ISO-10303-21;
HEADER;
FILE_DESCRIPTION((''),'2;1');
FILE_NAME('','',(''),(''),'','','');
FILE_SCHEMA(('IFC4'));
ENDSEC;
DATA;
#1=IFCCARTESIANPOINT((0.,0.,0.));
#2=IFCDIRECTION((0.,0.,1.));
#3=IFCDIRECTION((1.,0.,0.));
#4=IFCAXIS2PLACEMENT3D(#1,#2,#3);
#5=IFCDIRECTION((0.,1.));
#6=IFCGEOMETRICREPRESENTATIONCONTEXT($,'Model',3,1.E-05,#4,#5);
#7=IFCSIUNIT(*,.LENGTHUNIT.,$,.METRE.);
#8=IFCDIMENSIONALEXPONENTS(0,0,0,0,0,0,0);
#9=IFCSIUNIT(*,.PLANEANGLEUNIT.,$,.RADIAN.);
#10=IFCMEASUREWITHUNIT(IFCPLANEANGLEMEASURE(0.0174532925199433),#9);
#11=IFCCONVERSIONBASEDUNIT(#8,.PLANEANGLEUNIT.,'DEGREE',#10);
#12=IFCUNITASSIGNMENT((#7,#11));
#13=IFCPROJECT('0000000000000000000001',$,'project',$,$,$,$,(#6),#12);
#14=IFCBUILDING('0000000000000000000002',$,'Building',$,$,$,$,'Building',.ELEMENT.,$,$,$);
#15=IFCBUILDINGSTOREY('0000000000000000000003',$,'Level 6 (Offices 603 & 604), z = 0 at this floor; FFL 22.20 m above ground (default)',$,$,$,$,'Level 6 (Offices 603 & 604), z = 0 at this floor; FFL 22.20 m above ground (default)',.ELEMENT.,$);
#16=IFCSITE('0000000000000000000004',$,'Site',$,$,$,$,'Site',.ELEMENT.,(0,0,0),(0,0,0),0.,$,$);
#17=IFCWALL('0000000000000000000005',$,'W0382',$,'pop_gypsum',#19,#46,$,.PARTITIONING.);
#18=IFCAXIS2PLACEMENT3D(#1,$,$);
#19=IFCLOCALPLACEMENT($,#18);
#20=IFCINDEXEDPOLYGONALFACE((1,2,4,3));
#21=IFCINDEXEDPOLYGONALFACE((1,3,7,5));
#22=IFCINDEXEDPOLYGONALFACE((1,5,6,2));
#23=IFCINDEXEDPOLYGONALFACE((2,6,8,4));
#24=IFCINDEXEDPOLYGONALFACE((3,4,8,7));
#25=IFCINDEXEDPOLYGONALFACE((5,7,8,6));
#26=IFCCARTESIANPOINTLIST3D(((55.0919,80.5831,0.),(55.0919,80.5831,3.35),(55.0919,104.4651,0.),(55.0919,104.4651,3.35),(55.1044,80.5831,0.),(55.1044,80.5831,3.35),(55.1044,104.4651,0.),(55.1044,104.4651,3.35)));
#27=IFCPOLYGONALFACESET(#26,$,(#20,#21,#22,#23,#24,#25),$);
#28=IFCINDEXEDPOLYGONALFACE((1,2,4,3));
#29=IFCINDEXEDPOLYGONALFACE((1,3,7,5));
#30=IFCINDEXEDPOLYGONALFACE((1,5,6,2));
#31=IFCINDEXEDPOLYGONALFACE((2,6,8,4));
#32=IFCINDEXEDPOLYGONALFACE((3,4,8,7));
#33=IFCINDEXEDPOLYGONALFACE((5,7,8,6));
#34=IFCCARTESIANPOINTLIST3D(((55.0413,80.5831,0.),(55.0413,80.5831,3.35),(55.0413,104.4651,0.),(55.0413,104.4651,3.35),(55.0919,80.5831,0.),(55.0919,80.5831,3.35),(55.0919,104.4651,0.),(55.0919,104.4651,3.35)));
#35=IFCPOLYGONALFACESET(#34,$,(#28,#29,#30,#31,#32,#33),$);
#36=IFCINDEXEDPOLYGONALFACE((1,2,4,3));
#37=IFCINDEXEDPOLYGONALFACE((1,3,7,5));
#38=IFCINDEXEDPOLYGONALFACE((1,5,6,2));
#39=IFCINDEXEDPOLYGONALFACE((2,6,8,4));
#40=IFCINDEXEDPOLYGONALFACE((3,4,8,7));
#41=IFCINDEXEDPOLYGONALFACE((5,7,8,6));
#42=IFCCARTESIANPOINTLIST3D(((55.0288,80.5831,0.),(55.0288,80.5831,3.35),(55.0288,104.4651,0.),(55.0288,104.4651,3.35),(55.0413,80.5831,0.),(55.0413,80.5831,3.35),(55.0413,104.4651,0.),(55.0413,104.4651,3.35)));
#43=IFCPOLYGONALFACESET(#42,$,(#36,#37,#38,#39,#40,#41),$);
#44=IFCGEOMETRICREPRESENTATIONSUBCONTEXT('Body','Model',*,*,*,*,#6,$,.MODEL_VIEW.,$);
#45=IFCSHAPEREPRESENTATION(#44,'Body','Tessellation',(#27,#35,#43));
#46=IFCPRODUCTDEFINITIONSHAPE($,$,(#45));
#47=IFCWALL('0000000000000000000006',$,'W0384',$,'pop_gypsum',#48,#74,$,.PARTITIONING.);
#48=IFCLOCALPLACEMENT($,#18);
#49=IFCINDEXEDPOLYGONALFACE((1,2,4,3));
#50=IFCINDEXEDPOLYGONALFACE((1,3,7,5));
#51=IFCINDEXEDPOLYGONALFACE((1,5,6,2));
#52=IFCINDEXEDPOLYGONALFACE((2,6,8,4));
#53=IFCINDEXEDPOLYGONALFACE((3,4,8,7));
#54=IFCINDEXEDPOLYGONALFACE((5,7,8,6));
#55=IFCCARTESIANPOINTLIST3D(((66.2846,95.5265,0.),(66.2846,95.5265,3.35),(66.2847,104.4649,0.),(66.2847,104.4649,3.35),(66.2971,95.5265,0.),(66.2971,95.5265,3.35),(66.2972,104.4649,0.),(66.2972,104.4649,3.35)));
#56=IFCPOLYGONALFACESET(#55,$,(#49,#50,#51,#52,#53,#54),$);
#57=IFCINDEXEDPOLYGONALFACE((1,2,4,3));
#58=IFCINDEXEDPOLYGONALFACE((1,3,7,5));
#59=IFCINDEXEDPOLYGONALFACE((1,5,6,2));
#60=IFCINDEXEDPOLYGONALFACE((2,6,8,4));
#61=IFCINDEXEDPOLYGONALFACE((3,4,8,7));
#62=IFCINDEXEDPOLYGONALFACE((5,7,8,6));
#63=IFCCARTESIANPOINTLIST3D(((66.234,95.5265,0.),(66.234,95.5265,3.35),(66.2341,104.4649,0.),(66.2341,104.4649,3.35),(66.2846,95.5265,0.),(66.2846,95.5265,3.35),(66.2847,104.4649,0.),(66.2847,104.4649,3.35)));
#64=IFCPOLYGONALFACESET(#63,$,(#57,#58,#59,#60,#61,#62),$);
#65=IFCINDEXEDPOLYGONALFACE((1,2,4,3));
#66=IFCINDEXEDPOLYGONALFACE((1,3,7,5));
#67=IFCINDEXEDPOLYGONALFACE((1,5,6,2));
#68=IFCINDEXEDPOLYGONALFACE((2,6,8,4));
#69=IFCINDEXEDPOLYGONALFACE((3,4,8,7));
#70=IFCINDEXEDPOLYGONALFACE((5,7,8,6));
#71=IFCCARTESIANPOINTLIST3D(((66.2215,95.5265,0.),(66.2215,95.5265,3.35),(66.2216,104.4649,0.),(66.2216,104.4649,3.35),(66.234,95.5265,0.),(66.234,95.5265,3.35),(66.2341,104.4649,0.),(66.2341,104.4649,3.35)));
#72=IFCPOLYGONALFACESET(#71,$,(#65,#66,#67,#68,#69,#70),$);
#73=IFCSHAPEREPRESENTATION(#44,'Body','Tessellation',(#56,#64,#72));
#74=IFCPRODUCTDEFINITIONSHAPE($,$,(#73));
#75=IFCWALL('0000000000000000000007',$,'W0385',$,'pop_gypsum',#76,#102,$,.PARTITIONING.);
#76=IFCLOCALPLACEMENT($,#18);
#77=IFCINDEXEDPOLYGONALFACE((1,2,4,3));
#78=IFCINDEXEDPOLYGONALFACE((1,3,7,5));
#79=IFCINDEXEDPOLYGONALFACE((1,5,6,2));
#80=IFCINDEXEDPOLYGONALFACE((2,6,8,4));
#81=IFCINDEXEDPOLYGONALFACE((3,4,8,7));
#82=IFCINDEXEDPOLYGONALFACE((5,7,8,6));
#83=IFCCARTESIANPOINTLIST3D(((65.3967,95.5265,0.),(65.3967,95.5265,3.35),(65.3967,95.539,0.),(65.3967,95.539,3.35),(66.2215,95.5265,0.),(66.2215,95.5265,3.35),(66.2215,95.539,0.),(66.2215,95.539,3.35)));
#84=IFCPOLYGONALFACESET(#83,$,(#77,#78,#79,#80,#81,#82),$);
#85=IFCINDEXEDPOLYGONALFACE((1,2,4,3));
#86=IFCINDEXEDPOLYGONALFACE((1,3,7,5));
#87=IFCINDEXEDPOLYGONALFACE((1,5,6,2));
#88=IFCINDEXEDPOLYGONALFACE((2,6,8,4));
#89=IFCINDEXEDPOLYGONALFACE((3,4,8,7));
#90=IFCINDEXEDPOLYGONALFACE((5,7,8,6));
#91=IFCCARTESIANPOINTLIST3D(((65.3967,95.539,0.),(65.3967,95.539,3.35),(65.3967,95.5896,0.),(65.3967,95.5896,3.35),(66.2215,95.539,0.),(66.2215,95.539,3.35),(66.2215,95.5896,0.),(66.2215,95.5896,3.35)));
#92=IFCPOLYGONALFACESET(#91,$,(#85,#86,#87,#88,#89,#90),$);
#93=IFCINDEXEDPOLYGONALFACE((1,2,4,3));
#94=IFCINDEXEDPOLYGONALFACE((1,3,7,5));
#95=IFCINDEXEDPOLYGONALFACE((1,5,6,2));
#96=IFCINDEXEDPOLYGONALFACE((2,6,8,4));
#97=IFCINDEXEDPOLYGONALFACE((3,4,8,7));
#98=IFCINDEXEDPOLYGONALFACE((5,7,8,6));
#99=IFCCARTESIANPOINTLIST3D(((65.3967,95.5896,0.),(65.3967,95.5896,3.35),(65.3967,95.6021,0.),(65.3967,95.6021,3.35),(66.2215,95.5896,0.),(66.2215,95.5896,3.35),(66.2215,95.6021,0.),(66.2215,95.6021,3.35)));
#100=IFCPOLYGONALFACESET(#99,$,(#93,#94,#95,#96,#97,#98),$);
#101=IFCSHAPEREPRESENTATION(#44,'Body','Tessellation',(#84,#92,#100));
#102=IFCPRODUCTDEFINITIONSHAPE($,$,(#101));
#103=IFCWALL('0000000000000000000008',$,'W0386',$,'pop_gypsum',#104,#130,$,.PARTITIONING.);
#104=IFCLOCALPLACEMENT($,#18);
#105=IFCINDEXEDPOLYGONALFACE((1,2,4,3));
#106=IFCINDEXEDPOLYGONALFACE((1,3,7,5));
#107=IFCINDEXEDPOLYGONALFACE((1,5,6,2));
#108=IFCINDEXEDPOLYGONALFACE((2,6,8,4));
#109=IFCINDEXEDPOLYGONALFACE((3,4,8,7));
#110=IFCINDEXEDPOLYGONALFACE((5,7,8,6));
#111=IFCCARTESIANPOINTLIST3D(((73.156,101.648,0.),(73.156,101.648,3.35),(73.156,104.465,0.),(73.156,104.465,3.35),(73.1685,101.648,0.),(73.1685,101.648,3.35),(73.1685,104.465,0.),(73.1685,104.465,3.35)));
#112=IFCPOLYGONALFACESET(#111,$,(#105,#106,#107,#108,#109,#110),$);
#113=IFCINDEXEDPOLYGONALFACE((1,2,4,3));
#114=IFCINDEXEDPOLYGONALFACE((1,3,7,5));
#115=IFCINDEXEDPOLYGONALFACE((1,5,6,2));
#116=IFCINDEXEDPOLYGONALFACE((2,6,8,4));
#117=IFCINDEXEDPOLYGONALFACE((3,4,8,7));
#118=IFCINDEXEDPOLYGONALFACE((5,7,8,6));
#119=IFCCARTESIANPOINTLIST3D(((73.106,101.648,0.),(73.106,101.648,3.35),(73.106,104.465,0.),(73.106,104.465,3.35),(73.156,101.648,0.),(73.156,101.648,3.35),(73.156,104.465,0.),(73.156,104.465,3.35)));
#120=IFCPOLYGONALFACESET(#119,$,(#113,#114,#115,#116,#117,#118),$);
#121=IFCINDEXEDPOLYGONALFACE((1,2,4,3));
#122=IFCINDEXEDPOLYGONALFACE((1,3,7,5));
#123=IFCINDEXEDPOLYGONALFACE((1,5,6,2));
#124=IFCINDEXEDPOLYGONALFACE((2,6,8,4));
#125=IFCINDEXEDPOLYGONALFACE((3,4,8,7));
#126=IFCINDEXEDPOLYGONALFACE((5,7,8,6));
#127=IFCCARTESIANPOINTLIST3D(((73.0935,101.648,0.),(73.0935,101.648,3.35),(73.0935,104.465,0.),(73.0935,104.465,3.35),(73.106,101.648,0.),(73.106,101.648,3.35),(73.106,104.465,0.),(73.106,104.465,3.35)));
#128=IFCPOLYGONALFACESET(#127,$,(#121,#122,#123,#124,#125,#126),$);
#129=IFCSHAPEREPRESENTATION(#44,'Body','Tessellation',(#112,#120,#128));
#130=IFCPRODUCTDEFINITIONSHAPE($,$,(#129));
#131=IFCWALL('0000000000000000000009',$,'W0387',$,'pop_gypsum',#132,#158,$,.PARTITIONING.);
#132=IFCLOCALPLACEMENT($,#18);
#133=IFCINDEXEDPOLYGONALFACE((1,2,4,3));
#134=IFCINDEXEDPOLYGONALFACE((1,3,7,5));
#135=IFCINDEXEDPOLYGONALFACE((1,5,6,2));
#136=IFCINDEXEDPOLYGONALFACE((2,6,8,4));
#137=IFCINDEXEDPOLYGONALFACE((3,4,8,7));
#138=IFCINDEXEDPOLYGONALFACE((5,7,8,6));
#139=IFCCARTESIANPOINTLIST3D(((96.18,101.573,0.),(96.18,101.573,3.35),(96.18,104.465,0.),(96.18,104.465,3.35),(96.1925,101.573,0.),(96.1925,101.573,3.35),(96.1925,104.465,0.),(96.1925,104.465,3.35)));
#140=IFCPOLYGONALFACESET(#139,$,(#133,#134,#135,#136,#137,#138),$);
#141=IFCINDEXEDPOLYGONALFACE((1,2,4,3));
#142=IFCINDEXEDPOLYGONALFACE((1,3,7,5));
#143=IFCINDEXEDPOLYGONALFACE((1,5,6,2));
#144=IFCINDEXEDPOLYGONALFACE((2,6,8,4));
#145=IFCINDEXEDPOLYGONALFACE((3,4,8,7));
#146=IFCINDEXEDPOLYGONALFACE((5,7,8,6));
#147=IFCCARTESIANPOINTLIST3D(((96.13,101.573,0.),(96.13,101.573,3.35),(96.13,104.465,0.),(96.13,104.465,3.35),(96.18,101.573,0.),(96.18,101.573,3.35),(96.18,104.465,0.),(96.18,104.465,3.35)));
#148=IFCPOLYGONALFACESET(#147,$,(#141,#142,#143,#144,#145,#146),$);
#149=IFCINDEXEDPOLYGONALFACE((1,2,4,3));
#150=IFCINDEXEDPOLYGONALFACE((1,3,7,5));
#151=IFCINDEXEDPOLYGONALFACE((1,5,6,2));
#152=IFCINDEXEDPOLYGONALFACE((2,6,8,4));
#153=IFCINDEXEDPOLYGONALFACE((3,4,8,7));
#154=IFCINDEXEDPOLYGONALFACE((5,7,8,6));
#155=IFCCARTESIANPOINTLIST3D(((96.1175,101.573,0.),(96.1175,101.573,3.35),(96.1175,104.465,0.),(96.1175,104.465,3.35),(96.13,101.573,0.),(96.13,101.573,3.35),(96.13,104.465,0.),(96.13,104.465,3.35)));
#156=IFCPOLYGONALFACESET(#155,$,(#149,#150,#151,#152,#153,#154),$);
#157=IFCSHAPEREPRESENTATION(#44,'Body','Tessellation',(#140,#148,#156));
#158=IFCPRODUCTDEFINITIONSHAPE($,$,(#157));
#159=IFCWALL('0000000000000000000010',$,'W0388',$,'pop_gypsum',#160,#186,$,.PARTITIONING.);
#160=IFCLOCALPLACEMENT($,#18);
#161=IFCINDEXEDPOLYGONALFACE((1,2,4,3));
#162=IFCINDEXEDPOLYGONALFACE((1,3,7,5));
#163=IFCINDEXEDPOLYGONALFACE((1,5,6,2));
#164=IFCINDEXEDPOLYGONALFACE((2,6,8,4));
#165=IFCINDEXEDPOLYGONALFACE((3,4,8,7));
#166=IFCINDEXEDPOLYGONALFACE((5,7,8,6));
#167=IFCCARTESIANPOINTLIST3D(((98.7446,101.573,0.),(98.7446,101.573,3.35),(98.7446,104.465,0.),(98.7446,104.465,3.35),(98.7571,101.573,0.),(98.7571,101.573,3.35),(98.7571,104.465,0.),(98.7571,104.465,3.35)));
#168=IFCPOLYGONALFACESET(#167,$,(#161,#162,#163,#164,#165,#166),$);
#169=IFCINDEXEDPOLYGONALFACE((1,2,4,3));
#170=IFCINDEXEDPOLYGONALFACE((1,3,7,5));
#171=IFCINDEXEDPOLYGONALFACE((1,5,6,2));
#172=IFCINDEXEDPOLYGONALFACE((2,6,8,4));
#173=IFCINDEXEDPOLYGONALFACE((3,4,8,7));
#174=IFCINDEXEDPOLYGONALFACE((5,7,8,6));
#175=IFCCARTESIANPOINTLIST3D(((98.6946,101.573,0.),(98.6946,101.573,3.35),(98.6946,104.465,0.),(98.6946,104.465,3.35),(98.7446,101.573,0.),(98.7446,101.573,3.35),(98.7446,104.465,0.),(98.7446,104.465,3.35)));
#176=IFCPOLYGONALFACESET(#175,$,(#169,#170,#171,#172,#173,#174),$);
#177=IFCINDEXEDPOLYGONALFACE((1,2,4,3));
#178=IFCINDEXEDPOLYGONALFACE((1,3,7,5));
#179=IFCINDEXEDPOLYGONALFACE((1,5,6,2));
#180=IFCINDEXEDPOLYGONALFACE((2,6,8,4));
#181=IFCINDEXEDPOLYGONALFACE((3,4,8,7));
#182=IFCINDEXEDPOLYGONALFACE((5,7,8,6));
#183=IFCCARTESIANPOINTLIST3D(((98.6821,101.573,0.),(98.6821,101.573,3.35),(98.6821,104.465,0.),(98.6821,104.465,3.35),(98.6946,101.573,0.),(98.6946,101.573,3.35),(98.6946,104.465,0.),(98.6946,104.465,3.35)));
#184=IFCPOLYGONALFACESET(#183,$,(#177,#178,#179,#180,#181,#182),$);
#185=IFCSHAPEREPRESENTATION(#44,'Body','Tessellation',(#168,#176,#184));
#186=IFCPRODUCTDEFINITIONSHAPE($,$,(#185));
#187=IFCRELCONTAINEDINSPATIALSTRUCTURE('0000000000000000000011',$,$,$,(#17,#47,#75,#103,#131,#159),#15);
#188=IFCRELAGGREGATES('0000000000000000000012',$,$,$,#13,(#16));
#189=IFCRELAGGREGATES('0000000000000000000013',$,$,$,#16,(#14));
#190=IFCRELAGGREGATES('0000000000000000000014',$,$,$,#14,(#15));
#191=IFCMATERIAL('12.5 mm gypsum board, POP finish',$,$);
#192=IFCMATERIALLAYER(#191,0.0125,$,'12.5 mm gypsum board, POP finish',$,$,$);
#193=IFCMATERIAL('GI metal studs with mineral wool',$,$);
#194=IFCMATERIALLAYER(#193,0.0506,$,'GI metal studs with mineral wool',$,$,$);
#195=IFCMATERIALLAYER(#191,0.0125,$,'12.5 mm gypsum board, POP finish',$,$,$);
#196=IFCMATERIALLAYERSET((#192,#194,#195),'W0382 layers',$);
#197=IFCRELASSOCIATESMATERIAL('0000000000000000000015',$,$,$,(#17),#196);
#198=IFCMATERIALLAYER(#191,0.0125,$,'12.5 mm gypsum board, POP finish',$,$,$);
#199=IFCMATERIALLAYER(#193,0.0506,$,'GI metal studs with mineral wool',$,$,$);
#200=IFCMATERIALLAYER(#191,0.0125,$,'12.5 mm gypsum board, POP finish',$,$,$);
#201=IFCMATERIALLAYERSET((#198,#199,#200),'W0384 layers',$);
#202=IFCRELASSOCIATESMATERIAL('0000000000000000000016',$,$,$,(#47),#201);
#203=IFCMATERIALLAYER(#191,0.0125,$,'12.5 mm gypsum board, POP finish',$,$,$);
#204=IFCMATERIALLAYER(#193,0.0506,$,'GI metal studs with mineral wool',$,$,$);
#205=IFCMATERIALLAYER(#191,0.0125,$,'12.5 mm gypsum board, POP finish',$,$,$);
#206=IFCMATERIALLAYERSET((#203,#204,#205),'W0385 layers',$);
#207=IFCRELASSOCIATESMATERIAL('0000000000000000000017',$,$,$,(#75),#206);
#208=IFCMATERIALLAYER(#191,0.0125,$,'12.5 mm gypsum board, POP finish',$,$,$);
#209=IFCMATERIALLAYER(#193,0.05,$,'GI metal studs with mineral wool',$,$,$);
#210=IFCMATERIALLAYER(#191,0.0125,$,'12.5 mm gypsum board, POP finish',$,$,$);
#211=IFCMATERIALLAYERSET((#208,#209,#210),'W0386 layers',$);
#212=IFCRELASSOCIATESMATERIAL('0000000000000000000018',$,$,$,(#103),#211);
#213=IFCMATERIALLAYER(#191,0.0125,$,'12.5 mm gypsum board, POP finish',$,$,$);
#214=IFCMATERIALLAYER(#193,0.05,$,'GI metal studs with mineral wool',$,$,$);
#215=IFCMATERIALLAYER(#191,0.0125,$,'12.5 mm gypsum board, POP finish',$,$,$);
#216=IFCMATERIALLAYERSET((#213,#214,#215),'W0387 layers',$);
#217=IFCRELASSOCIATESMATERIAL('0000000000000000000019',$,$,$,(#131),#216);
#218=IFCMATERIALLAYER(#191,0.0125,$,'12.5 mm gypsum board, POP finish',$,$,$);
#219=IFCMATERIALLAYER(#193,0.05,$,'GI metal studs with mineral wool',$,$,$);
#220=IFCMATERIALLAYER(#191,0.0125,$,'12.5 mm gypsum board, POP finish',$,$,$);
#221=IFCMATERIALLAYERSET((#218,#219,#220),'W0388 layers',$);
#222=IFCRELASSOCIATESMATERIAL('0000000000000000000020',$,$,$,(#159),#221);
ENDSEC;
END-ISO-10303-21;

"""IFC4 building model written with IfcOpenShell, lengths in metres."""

from ifc_helpers import new_model, entity, si_unit, converted_unit, direction, frame, frame_2d, origin_with_axes, place, context, subcontext, project, spatial, rectangle, extrude, material, layer, layer_set, layer_usage, element, save


model = new_model("IFC4")

# Units and contexts
model_context = context("Model", 3, precision=1e-05, world=origin_with_axes(), true_north=direction((0.0, 1.0)))
body_context = subcontext(model_context, "Body", "Model", "MODEL_VIEW")
ifc_project = project(units=[si_unit("LENGTHUNIT", "METRE"), converted_unit("PLANEANGLEUNIT", "DEGREE", entity("IfcPlaneAngleMeasure", 0.0174532925199433), si_unit("PLANEANGLEUNIT", "RADIAN"), dimensions=[0, 0, 0, 0, 0, 0, 0])], contexts=[model_context])

# Site, building, storey
site = spatial("IfcSite", under=ifc_project, Name="Site", LongName="Site", CompositionType="ELEMENT", RefLatitude=(0, 0, 0), RefLongitude=(0, 0, 0), RefElevation=0.0)
building = spatial("IfcBuilding", under=site, Name="Building", LongName="Building", CompositionType="ELEMENT")
storey = spatial("IfcBuildingStorey", under=building, Name="Level 6 (Offices 603 & 604), z = 0 at this floor; FFL 22.20 m above ground (default)", LongName="Level 6 (Offices 603 & 604), z = 0 at this floor; FFL 22.20 m above ground (default)", CompositionType="ELEMENT")

# Shared definitions
placement = place(None, origin_with_axes())

# Walls
ifc_material_1 = material(Name="12.5 mm gypsum board, POP finish")
ifc_material_2 = material(Name="GI metal studs with mineral wool")
ifc_layer_1 = layer(ifc_material_1, 0.0125, Name="12.5 mm gypsum board, POP finish")
ifc_layer_2 = layer(ifc_material_2, 0.0506, Name="GI metal studs with mineral wool")
ifc_layer_3 = layer(ifc_material_1, 0.0125, Name="12.5 mm gypsum board, POP finish")
ifc_layer_set_1 = layer_set([ifc_layer_1, ifc_layer_2, ifc_layer_3], Name="W0382 layers")
ifc_layer_usage_1 = layer_usage(ifc_layer_set_1, "AXIS2", "POSITIVE", -0.0378)
element("IfcWall", 1, at=placement, inside=storey, material=ifc_layer_usage_1, Name="W0382", ObjectType="pop_gypsum", PredefinedType="PARTITIONING", context=body_context, shape_type="SweptSolid", body=[
    extrude(rectangle(XDim=23.882, YDim=0.0125, at=frame_2d((0.0, 0.0), x_axis=(0.0, 1.0))), frame((55.0981, 92.5241, 0.0), z_axis=(0.0, 0.0, 1.0), x_axis=(1.0, 0.0, 0.0)), (0.0, 0.0, 1.0), 3.35),
    extrude(rectangle(XDim=23.882, YDim=0.0506, at=frame_2d((-0.0315, 0.0), x_axis=(0.0, 1.0))), frame((55.0981, 92.5241, 0.0), z_axis=(0.0, 0.0, 1.0), x_axis=(1.0, 0.0, 0.0)), (0.0, 0.0, 1.0), 3.35),
    extrude(rectangle(XDim=23.882, YDim=0.0125, at=frame_2d((-0.0631, 0.0), x_axis=(0.0, 1.0))), frame((55.0981, 92.5241, 0.0), z_axis=(0.0, 0.0, 1.0), x_axis=(1.0, 0.0, 0.0)), (0.0, 0.0, 1.0), 3.35),
])
ifc_layer_4 = layer(ifc_material_1, 0.0125, Name="12.5 mm gypsum board, POP finish")
ifc_layer_5 = layer(ifc_material_2, 0.0506, Name="GI metal studs with mineral wool")
ifc_layer_6 = layer(ifc_material_1, 0.0125, Name="12.5 mm gypsum board, POP finish")
ifc_layer_set_2 = layer_set([ifc_layer_4, ifc_layer_5, ifc_layer_6], Name="W0384 layers")
ifc_layer_usage_2 = layer_usage(ifc_layer_set_2, "AXIS2", "POSITIVE", -0.0378)
element("IfcWall", 2, at=placement, inside=storey, material=ifc_layer_usage_2, Name="W0384", ObjectType="pop_gypsum", PredefinedType="PARTITIONING", context=body_context, shape_type="SweptSolid", body=[
    extrude(rectangle(XDim=8.9384, YDim=0.0125, at=frame_2d((0.0, 0.0), x_axis=(0.000011, 1.0))), frame((66.2909, 99.9957, 0.0), z_axis=(0.0, 0.0, 1.0), x_axis=(1.0, 0.0, 0.0)), (0.0, 0.0, 1.0), 3.35),
    extrude(rectangle(XDim=8.9384, YDim=0.0506, at=frame_2d((-0.0315, 0.0), x_axis=(0.000011, 1.0))), frame((66.2909, 99.9957, 0.0), z_axis=(0.0, 0.0, 1.0), x_axis=(1.0, 0.0, 0.0)), (0.0, 0.0, 1.0), 3.35),
    extrude(rectangle(XDim=8.9384, YDim=0.0125, at=frame_2d((-0.0631, 0.0), x_axis=(0.000011, 1.0))), frame((66.2909, 99.9957, 0.0), z_axis=(0.0, 0.0, 1.0), x_axis=(1.0, 0.0, 0.0)), (0.0, 0.0, 1.0), 3.35),
])
ifc_layer_7 = layer(ifc_material_1, 0.0125, Name="12.5 mm gypsum board, POP finish")
ifc_layer_8 = layer(ifc_material_2, 0.0506, Name="GI metal studs with mineral wool")
ifc_layer_9 = layer(ifc_material_1, 0.0125, Name="12.5 mm gypsum board, POP finish")
ifc_layer_set_3 = layer_set([ifc_layer_7, ifc_layer_8, ifc_layer_9], Name="W0385 layers")
ifc_layer_usage_3 = layer_usage(ifc_layer_set_3, "AXIS2", "POSITIVE", -0.0378)
element("IfcWall", 3, at=placement, inside=storey, material=ifc_layer_usage_3, Name="W0385", ObjectType="pop_gypsum", PredefinedType="PARTITIONING", context=body_context, shape_type="SweptSolid", body=[
    extrude(rectangle(XDim=0.8248, YDim=0.0125, at=frame_2d((0.0, 0.0), x_axis=(1.0, 0.0))), frame((65.8091, 95.5327, 0.0), z_axis=(0.0, 0.0, 1.0), x_axis=(1.0, 0.0, 0.0)), (0.0, 0.0, 1.0), 3.35),
    extrude(rectangle(XDim=0.8248, YDim=0.0506, at=frame_2d((0.0, 0.0315), x_axis=(1.0, 0.0))), frame((65.8091, 95.5327, 0.0), z_axis=(0.0, 0.0, 1.0), x_axis=(1.0, 0.0, 0.0)), (0.0, 0.0, 1.0), 3.35),
    extrude(rectangle(XDim=0.8248, YDim=0.0125, at=frame_2d((0.0, 0.0631), x_axis=(1.0, 0.0))), frame((65.8091, 95.5327, 0.0), z_axis=(0.0, 0.0, 1.0), x_axis=(1.0, 0.0, 0.0)), (0.0, 0.0, 1.0), 3.35),
])
ifc_layer_10 = layer(ifc_material_1, 0.0125, Name="12.5 mm gypsum board, POP finish")
ifc_layer_11 = layer(ifc_material_2, 0.05, Name="GI metal studs with mineral wool")
ifc_layer_12 = layer(ifc_material_1, 0.0125, Name="12.5 mm gypsum board, POP finish")
ifc_layer_set_4 = layer_set([ifc_layer_10, ifc_layer_11, ifc_layer_12], Name="W0386 layers")
ifc_layer_usage_4 = layer_usage(ifc_layer_set_4, "AXIS2", "POSITIVE", -0.0375)
element("IfcWall", 4, at=placement, inside=storey, material=ifc_layer_usage_4, Name="W0386", ObjectType="pop_gypsum", PredefinedType="PARTITIONING", context=body_context, shape_type="SweptSolid", body=[
    extrude(rectangle(XDim=2.817, YDim=0.0125, at=frame_2d((0.0, 0.0), x_axis=(0.0, 1.0))), frame((73.1623, 103.0565, 0.0), z_axis=(0.0, 0.0, 1.0), x_axis=(1.0, 0.0, 0.0)), (0.0, 0.0, 1.0), 3.35),
    extrude(rectangle(XDim=2.817, YDim=0.05, at=frame_2d((-0.0312, 0.0), x_axis=(0.0, 1.0))), frame((73.1623, 103.0565, 0.0), z_axis=(0.0, 0.0, 1.0), x_axis=(1.0, 0.0, 0.0)), (0.0, 0.0, 1.0), 3.35),
    extrude(rectangle(XDim=2.817, YDim=0.0125, at=frame_2d((-0.0625, 0.0), x_axis=(0.0, 1.0))), frame((73.1623, 103.0565, 0.0), z_axis=(0.0, 0.0, 1.0), x_axis=(1.0, 0.0, 0.0)), (0.0, 0.0, 1.0), 3.35),
])
ifc_layer_13 = layer(ifc_material_1, 0.0125, Name="12.5 mm gypsum board, POP finish")
ifc_layer_14 = layer(ifc_material_2, 0.05, Name="GI metal studs with mineral wool")
ifc_layer_15 = layer(ifc_material_1, 0.0125, Name="12.5 mm gypsum board, POP finish")
ifc_layer_set_5 = layer_set([ifc_layer_13, ifc_layer_14, ifc_layer_15], Name="W0387 layers")
ifc_layer_usage_5 = layer_usage(ifc_layer_set_5, "AXIS2", "POSITIVE", -0.0375)
element("IfcWall", 5, at=placement, inside=storey, material=ifc_layer_usage_5, Name="W0387", ObjectType="pop_gypsum", PredefinedType="PARTITIONING", context=body_context, shape_type="SweptSolid", body=[
    extrude(rectangle(XDim=2.892, YDim=0.0125, at=frame_2d((0.0, 0.0), x_axis=(0.0, 1.0))), frame((96.1863, 103.019, 0.0), z_axis=(0.0, 0.0, 1.0), x_axis=(1.0, 0.0, 0.0)), (0.0, 0.0, 1.0), 3.35),
    extrude(rectangle(XDim=2.892, YDim=0.05, at=frame_2d((-0.0312, 0.0), x_axis=(0.0, 1.0))), frame((96.1863, 103.019, 0.0), z_axis=(0.0, 0.0, 1.0), x_axis=(1.0, 0.0, 0.0)), (0.0, 0.0, 1.0), 3.35),
    extrude(rectangle(XDim=2.892, YDim=0.0125, at=frame_2d((-0.0625, 0.0), x_axis=(0.0, 1.0))), frame((96.1863, 103.019, 0.0), z_axis=(0.0, 0.0, 1.0), x_axis=(1.0, 0.0, 0.0)), (0.0, 0.0, 1.0), 3.35),
])
ifc_layer_16 = layer(ifc_material_1, 0.0125, Name="12.5 mm gypsum board, POP finish")
ifc_layer_17 = layer(ifc_material_2, 0.05, Name="GI metal studs with mineral wool")
ifc_layer_18 = layer(ifc_material_1, 0.0125, Name="12.5 mm gypsum board, POP finish")
ifc_layer_set_6 = layer_set([ifc_layer_16, ifc_layer_17, ifc_layer_18], Name="W0388 layers")
ifc_layer_usage_6 = layer_usage(ifc_layer_set_6, "AXIS2", "POSITIVE", -0.0375)
element("IfcWall", 6, at=placement, inside=storey, material=ifc_layer_usage_6, Name="W0388", ObjectType="pop_gypsum", PredefinedType="PARTITIONING", context=body_context, shape_type="SweptSolid", body=[
    extrude(rectangle(XDim=2.892, YDim=0.0125, at=frame_2d((0.0, 0.0), x_axis=(0.0, 1.0))), frame((98.7508, 103.019, 0.0), z_axis=(0.0, 0.0, 1.0), x_axis=(1.0, 0.0, 0.0)), (0.0, 0.0, 1.0), 3.35),
    extrude(rectangle(XDim=2.892, YDim=0.05, at=frame_2d((-0.0312, 0.0), x_axis=(0.0, 1.0))), frame((98.7508, 103.019, 0.0), z_axis=(0.0, 0.0, 1.0), x_axis=(1.0, 0.0, 0.0)), (0.0, 0.0, 1.0), 3.35),
    extrude(rectangle(XDim=2.892, YDim=0.0125, at=frame_2d((-0.0625, 0.0), x_axis=(0.0, 1.0))), frame((98.7508, 103.019, 0.0), z_axis=(0.0, 0.0, 1.0), x_axis=(1.0, 0.0, 0.0)), (0.0, 0.0, 1.0), 3.35),
])

save(model, "model.ifc")
